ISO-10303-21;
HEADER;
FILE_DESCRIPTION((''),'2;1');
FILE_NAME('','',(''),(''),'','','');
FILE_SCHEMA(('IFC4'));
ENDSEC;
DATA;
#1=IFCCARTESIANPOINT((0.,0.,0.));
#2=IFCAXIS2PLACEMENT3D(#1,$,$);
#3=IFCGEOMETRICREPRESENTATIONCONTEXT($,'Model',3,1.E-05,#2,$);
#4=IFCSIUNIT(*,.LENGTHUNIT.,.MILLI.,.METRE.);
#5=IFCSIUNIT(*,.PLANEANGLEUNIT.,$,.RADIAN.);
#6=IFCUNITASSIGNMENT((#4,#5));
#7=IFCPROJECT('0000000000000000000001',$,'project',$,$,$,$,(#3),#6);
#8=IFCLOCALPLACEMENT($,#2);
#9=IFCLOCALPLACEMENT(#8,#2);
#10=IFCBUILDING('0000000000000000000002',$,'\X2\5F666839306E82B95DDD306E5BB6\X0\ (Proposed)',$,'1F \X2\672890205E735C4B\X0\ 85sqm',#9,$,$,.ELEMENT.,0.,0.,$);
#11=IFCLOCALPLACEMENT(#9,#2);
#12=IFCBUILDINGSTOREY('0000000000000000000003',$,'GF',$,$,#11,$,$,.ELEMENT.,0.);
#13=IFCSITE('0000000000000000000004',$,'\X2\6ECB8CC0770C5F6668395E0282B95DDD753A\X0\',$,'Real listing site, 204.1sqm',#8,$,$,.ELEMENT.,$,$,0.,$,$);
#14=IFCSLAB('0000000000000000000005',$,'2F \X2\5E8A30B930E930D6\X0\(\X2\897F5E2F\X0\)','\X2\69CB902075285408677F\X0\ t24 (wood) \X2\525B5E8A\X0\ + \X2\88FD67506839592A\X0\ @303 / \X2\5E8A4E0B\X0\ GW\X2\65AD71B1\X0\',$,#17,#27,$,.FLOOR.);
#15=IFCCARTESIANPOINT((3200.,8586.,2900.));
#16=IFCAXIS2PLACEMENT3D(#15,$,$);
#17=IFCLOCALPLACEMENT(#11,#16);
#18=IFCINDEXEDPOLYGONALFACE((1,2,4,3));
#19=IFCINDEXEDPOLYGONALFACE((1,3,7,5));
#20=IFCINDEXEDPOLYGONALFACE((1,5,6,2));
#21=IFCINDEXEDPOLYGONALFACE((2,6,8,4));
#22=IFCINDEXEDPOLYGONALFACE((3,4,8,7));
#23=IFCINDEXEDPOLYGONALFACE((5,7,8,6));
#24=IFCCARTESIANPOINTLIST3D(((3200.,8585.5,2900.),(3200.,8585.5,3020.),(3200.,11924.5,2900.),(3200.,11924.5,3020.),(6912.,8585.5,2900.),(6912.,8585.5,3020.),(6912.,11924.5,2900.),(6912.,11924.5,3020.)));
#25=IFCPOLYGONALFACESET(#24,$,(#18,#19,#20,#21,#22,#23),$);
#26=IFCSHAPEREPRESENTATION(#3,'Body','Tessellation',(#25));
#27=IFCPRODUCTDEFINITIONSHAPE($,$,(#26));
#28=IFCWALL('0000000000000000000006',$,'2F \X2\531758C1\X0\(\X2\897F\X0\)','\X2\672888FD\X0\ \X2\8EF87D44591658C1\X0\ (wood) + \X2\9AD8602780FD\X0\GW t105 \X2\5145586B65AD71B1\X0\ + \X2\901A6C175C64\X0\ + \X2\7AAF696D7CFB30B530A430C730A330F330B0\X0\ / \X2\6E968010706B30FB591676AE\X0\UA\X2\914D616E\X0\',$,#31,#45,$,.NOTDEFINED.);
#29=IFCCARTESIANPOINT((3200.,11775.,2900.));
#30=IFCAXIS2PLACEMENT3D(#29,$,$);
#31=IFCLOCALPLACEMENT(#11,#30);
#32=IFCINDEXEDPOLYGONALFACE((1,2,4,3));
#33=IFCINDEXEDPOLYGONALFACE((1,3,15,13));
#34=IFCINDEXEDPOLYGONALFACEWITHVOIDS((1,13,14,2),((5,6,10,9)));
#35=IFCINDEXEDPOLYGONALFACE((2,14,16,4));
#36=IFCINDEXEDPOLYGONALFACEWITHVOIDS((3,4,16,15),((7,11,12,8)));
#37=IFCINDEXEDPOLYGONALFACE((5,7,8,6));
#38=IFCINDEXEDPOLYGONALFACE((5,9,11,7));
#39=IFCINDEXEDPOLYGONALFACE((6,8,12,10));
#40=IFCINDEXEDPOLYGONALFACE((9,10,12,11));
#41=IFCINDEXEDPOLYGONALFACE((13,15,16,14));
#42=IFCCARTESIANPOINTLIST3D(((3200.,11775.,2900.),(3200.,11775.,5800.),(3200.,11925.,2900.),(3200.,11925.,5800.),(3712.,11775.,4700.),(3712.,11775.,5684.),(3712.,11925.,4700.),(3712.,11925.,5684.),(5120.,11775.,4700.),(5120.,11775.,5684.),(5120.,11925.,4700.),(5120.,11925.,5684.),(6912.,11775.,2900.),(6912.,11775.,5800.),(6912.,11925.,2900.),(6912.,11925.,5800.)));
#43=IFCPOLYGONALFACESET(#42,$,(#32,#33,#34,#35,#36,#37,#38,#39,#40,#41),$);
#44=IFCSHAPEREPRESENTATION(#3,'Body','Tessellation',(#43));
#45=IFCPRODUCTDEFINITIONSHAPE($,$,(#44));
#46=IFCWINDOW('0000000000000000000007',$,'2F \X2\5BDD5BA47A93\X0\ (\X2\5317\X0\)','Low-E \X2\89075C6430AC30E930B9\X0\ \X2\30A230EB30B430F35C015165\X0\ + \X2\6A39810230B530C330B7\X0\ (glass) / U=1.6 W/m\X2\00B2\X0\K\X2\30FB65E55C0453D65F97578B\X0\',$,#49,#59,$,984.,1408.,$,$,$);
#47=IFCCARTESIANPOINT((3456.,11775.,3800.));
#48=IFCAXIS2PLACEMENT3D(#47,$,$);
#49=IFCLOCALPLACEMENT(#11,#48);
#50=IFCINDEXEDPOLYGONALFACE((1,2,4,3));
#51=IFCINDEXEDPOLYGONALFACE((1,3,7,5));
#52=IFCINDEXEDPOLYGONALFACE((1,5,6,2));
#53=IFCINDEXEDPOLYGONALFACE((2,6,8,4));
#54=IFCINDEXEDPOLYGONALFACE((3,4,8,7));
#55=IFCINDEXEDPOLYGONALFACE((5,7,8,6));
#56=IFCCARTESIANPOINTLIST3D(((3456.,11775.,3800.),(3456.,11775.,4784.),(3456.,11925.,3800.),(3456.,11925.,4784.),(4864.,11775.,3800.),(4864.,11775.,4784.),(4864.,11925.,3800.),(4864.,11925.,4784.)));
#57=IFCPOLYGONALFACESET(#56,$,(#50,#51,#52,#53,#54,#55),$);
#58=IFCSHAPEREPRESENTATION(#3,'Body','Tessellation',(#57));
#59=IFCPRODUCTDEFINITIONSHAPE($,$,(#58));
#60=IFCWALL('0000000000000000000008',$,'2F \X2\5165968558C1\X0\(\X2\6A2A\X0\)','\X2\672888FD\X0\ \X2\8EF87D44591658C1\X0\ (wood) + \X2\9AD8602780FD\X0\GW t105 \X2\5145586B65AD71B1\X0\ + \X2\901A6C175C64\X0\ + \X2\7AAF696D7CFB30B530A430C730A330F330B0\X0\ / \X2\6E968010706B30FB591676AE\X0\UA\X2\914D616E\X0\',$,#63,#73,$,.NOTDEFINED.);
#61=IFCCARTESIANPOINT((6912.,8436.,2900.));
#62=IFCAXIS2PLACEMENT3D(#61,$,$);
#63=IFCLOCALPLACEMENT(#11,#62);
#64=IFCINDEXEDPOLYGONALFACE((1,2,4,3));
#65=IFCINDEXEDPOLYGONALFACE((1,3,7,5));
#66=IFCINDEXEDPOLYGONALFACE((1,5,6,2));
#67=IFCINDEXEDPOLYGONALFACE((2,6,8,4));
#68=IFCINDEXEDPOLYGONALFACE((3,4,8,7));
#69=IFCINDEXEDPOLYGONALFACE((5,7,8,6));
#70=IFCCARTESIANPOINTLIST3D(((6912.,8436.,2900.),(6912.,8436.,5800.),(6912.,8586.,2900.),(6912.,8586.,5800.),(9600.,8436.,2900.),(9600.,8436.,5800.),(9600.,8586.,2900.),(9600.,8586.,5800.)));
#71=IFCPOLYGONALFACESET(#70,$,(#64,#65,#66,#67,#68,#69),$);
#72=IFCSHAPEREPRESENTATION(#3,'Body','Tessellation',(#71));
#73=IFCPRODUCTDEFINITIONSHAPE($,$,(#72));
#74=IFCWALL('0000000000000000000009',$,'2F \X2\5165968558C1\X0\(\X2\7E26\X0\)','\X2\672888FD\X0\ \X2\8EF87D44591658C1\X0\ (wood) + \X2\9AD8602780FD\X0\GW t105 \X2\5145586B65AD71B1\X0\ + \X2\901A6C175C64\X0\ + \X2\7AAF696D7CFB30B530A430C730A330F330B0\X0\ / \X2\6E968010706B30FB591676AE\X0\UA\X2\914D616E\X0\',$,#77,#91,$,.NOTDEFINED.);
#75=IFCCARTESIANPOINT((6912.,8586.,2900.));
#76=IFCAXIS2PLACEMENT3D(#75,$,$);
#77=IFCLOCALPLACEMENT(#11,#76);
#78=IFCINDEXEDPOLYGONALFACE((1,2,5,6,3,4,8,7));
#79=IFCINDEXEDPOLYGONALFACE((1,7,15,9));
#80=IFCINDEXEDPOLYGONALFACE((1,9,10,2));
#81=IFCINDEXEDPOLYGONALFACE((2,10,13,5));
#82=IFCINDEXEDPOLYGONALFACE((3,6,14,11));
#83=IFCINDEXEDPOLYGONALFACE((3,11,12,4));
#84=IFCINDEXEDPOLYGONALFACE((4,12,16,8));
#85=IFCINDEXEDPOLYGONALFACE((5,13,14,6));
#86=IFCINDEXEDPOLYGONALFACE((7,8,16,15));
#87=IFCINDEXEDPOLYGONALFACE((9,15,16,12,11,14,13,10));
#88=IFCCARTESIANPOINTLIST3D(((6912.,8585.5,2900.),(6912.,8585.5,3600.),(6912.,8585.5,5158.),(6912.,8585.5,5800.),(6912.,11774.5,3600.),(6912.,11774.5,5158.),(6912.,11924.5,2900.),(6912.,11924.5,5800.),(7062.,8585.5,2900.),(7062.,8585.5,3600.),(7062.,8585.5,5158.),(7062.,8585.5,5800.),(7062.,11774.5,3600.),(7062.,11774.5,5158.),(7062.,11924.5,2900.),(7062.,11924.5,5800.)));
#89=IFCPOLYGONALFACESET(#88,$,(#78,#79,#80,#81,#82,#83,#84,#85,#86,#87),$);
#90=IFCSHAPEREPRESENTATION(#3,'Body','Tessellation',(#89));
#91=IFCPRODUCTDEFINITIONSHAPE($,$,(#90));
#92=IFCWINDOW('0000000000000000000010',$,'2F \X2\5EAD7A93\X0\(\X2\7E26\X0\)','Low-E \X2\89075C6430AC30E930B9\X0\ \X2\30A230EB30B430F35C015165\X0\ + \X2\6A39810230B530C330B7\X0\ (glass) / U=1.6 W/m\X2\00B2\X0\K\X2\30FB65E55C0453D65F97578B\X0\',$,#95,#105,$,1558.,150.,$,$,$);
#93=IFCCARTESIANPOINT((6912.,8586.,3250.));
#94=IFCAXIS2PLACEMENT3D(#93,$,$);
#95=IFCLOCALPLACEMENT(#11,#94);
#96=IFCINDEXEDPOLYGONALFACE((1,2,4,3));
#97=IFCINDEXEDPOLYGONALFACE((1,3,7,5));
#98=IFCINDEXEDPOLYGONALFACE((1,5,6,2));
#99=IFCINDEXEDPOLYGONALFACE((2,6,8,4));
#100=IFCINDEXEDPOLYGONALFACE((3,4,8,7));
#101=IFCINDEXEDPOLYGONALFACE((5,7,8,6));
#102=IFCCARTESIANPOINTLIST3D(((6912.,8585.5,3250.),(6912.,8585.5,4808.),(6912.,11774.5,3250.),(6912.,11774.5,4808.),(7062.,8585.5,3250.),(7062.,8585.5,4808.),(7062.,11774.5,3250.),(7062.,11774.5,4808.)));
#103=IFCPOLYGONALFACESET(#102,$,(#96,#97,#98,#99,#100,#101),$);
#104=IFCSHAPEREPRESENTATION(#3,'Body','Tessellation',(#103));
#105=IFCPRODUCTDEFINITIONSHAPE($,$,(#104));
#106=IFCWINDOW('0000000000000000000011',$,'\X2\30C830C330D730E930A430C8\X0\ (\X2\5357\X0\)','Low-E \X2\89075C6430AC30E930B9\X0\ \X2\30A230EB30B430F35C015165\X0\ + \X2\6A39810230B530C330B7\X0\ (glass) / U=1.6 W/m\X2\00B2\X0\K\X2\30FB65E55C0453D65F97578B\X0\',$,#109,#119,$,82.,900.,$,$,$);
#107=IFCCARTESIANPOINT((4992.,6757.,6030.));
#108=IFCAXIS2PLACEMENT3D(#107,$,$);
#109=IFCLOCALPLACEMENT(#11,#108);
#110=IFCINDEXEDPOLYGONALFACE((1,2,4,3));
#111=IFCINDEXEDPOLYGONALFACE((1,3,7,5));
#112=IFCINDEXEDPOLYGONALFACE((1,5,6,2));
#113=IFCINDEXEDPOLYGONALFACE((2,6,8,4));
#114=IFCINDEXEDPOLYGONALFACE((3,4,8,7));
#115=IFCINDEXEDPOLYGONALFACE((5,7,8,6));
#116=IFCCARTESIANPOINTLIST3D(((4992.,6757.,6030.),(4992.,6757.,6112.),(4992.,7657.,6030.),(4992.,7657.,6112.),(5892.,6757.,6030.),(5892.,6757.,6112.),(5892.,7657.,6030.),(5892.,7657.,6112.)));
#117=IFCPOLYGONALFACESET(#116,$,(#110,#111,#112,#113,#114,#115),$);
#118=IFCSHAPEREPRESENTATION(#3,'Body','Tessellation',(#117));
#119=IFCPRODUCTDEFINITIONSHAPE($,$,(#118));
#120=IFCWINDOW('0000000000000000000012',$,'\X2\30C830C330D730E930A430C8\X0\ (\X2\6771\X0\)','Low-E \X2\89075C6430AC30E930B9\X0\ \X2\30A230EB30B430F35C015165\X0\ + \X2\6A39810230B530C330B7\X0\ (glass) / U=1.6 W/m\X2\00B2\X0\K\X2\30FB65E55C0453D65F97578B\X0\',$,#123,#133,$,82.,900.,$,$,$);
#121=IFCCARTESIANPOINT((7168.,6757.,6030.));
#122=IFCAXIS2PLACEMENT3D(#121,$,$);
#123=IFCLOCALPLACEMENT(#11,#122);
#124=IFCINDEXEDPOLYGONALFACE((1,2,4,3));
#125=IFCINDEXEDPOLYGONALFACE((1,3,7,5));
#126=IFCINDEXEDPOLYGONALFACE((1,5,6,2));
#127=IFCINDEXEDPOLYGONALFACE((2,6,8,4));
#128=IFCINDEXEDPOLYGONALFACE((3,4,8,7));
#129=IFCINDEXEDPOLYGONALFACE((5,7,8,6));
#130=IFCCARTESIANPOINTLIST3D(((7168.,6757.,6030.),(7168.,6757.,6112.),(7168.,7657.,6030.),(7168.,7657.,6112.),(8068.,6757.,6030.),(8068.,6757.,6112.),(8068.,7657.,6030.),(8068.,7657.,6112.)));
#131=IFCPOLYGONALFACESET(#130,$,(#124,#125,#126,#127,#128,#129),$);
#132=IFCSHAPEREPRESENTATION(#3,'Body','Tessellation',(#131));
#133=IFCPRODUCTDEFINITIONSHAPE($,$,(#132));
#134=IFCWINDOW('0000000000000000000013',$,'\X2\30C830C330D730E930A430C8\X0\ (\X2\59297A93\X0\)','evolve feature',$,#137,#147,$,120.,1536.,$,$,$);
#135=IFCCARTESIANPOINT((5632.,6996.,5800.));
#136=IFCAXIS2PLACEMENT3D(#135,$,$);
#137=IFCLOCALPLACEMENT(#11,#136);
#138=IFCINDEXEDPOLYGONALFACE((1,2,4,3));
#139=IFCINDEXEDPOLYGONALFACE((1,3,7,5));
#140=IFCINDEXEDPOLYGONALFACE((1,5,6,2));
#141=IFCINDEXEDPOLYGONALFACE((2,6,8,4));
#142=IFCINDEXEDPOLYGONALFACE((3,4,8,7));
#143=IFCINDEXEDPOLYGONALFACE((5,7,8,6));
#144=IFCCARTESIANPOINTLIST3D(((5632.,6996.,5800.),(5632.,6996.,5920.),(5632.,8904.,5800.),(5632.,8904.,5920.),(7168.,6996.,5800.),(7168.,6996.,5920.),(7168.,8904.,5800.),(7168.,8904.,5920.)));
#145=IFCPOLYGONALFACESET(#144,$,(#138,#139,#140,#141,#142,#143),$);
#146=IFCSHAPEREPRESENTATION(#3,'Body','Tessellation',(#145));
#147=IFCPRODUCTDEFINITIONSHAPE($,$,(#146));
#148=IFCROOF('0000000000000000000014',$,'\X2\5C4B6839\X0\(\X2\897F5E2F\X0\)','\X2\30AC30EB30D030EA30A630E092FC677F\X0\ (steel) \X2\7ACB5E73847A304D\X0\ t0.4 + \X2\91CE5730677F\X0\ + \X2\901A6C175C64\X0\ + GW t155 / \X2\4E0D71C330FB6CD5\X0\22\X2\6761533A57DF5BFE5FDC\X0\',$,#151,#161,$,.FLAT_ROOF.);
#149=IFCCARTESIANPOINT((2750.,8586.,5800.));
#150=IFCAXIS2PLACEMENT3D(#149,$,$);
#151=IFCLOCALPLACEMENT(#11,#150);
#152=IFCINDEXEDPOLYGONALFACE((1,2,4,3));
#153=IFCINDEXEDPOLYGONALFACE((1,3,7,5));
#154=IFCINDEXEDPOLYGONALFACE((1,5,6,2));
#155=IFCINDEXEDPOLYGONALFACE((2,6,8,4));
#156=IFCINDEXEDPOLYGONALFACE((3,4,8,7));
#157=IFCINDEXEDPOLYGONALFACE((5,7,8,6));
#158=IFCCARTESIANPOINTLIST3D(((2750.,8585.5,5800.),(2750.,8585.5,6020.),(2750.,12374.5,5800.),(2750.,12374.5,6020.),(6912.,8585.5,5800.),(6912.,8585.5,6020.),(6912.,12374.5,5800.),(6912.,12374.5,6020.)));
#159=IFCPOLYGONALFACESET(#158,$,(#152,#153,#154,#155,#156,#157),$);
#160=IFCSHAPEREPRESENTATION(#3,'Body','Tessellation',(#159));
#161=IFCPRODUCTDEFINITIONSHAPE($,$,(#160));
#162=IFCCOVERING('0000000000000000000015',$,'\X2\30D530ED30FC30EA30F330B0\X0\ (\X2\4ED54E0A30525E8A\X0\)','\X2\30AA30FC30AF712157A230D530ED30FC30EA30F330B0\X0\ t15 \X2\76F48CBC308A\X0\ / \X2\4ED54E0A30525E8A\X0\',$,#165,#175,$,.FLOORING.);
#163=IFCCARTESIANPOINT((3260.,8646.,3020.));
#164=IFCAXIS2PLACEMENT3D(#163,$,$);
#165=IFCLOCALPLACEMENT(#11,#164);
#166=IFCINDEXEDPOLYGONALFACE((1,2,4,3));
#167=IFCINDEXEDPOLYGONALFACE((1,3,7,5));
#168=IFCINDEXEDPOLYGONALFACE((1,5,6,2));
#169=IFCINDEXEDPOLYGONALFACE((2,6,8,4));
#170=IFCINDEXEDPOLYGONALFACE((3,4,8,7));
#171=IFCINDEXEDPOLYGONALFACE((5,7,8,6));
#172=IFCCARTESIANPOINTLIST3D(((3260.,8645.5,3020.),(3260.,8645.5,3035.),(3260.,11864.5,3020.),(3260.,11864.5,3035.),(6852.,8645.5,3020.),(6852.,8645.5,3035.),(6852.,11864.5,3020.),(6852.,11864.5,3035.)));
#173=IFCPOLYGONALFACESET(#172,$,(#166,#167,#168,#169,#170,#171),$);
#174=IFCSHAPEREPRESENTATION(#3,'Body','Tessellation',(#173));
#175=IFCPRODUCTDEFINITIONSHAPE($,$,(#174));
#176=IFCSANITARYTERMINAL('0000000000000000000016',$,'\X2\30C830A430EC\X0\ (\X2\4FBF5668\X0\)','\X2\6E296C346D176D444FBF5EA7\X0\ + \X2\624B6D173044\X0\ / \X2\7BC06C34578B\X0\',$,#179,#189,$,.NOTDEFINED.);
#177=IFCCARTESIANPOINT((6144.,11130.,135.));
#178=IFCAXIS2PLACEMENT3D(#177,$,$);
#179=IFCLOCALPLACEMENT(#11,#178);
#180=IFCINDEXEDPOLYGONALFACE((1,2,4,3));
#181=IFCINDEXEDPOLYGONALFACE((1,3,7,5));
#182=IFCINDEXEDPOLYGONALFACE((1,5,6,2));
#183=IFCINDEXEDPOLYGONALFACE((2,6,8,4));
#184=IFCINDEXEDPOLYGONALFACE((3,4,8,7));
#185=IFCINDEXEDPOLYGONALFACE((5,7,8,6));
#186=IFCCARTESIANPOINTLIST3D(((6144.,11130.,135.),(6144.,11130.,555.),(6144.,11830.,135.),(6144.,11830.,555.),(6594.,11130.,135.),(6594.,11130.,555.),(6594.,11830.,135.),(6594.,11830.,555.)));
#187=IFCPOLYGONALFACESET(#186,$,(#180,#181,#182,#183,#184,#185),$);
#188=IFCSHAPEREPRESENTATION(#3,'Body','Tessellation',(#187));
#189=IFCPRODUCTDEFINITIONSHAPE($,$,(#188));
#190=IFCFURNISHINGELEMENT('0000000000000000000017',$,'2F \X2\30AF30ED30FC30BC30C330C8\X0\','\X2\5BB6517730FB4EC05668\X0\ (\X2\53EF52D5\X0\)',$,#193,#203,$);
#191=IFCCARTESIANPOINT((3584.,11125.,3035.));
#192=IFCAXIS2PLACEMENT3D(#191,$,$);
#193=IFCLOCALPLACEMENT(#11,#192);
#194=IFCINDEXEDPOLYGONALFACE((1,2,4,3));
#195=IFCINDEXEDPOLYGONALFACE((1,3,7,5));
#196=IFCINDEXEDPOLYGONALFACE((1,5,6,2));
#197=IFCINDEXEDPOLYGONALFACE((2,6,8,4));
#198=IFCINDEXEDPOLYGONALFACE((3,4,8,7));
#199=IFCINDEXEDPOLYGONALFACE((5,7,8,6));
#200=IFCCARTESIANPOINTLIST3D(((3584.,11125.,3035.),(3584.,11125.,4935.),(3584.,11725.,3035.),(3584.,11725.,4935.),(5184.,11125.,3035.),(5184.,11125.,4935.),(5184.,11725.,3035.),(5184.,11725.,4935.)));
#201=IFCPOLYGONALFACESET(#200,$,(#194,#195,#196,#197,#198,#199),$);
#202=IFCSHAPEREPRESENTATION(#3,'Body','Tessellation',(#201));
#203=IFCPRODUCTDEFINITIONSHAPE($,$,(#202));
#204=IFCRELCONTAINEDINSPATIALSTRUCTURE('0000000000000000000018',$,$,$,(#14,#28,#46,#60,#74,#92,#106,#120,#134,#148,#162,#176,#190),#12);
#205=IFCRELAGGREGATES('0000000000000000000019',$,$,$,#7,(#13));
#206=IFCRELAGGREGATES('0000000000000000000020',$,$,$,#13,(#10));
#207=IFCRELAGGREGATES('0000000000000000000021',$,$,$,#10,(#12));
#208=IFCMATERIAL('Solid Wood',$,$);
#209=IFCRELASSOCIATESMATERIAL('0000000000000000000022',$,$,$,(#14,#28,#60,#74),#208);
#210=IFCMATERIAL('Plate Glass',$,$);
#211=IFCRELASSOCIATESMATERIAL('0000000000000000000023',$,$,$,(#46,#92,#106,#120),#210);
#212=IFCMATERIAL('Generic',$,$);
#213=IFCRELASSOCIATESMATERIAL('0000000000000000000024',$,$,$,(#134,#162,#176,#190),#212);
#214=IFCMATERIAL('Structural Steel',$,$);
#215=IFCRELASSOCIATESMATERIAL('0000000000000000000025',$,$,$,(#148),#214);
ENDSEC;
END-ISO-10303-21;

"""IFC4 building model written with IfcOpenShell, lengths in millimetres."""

from ifc_helpers import new_model, si_unit, frame, frame_2d, origin, place, context, project, spatial, rectangle, extrude, material, element, fill, save


model = new_model("IFC4")

# Units and contexts
model_context = context("Model", 3, precision=1e-05, world=origin())
ifc_project = project(units=[si_unit("LENGTHUNIT", "METRE", prefix="MILLI"), si_unit("PLANEANGLEUNIT", "RADIAN")], contexts=[model_context])

# Site, building, storey
site_placement = place(None, origin())
site = spatial("IfcSite", under=ifc_project, at=site_placement, Name="滋賀県彦根市芹川町", ObjectType="Real listing site, 204.1sqm", CompositionType="ELEMENT", RefElevation=0.0)
building_placement = place(site_placement, origin())
building = spatial("IfcBuilding", under=site, at=building_placement, Name="彦根の芹川の家 (Proposed)", ObjectType="1F 木造平屋 85sqm", CompositionType="ELEMENT", ElevationOfRefHeight=0.0, ElevationOfTerrain=0.0)
storey_placement = place(building_placement, origin())
storey = spatial("IfcBuildingStorey", under=building, at=storey_placement, Name="GF", CompositionType="ELEMENT", Elevation=0.0)

# Slab
ifc_material_1 = material(Name="Solid Wood")
slab_placement = place(storey_placement, frame((3200.0, 8586.0, 2900.0)))
element("IfcSlab", 1, at=slab_placement, inside=storey, material=ifc_material_1, Name="2F 床スラブ(西帯)", Description="構造用合板 t24 (wood) 剛床 + 製材根太 @303 / 床下 GW断熱", PredefinedType="FLOOR", context=model_context, shape_type="SweptSolid", body=[
    extrude(rectangle(XDim=3712.0, YDim=3339.0, at=frame_2d((1856.0, 1669.0))), frame((3200.0, 8586.0, 2900.0)), (0.0, 0.0, 1.0), 120.0),
])

# Wall, opening, window
wall_1_placement = place(storey_placement, frame((3200.0, 11775.0, 2900.0)))
wall_1 = element("IfcWall", 2, at=wall_1_placement, inside=storey, material=ifc_material_1, Name="2F 北壁(西)", Description="木製 軸組外壁 (wood) + 高性能GW t105 充填断熱 + 通気層 + 窯業系サイディング / 準耐火・外皮UA配慮", PredefinedType="NOTDEFINED", context=model_context, shape_type="SweptSolid", body=[
    extrude(rectangle(XDim=3712.0, YDim=150.0, at=frame_2d((1856.0, 75.0))), frame((3200.0, 11775.0, 2900.0)), (0.0, 0.0, 1.0), 2900.0),
])
opening_1_placement = place(storey_placement, frame((3456.0, 11775.0, 3800.0)))
opening_1 = element("IfcOpeningElement", 3, at=opening_1_placement, cuts=wall_1, PredefinedType="NOTDEFINED", context=model_context, shape_type="SweptSolid", body=[
    extrude(rectangle(XDim=1408.0, YDim=150.0, at=frame_2d((704.0, 75.0))), frame((3456.0, 11775.0, 3800.0)), (0.0, 0.0, 1.0), 984.0),
])
ifc_material_2 = material(Name="Plate Glass")
window_1_placement = place(storey_placement, frame((3456.0, 11775.0, 3800.0)))
window_1 = element("IfcWindow", 4, at=window_1_placement, inside=storey, material=ifc_material_2, Name="2F 寝室窓 (北)", Description="Low-E 複層ガラス アルゴン封入 + 樹脂サッシ (glass) / U=1.6 W/m²K・日射取得型", OverallHeight=984.0, OverallWidth=1408.0, context=model_context, shape_type="SweptSolid", body=[
    extrude(rectangle(XDim=1408.0, YDim=150.0, at=frame_2d((704.0, 75.0))), frame((3456.0, 11775.0, 3800.0)), (0.0, 0.0, 1.0), 984.0),
])
fill(opening_1, window_1)

# Wall
wall_2_placement = place(storey_placement, frame((6912.0, 8436.0, 2900.0)))
element("IfcWall", 5, at=wall_2_placement, inside=storey, material=ifc_material_1, Name="2F 入隅壁(横)", Description="木製 軸組外壁 (wood) + 高性能GW t105 充填断熱 + 通気層 + 窯業系サイディング / 準耐火・外皮UA配慮", PredefinedType="NOTDEFINED", context=model_context, shape_type="SweptSolid", body=[
    extrude(rectangle(XDim=2688.0, YDim=150.0, at=frame_2d((1344.0, 75.0))), frame((6912.0, 8436.0, 2900.0)), (0.0, 0.0, 1.0), 2900.0),
])

# Wall, opening, window
wall_3_placement = place(storey_placement, frame((6912.0, 8586.0, 2900.0)))
wall_3 = element("IfcWall", 6, at=wall_3_placement, inside=storey, material=ifc_material_1, Name="2F 入隅壁(縦)", Description="木製 軸組外壁 (wood) + 高性能GW t105 充填断熱 + 通気層 + 窯業系サイディング / 準耐火・外皮UA配慮", PredefinedType="NOTDEFINED", context=model_context, shape_type="SweptSolid", body=[
    extrude(rectangle(XDim=150.0, YDim=3339.0, at=frame_2d((75.0, 1669.0))), frame((6912.0, 8586.0, 2900.0)), (0.0, 0.0, 1.0), 2900.0),
])
opening_2_placement = place(storey_placement, frame((6912.0, 8586.0, 3250.0)))
opening_2 = element("IfcOpeningElement", 7, at=opening_2_placement, cuts=wall_3, PredefinedType="NOTDEFINED", context=model_context, shape_type="SweptSolid", body=[
    extrude(rectangle(XDim=150.0, YDim=3189.0, at=frame_2d((75.0, 1594.0))), frame((6912.0, 8586.0, 3250.0)), (0.0, 0.0, 1.0), 1558.0),
])
window_2_placement = place(storey_placement, frame((6912.0, 8586.0, 3250.0)))
window_2 = element("IfcWindow", 8, at=window_2_placement, inside=storey, material=ifc_material_2, Name="2F 庭窓(縦)", Description="Low-E 複層ガラス アルゴン封入 + 樹脂サッシ (glass) / U=1.6 W/m²K・日射取得型", OverallHeight=1558.0, OverallWidth=150.0, context=model_context, shape_type="SweptSolid", body=[
    extrude(rectangle(XDim=150.0, YDim=3189.0, at=frame_2d((75.0, 1594.0))), frame((6912.0, 8586.0, 3250.0)), (0.0, 0.0, 1.0), 1558.0),
])
fill(opening_2, window_2)

# Windows
window_3_placement = place(storey_placement, frame((4992.0, 6757.0, 6030.0)))
element("IfcWindow", 9, at=window_3_placement, inside=storey, material=ifc_material_2, Name="トップライト (南)", Description="Low-E 複層ガラス アルゴン封入 + 樹脂サッシ (glass) / U=1.6 W/m²K・日射取得型", OverallHeight=82.0, OverallWidth=900.0, context=model_context, shape_type="SweptSolid", body=[
    extrude(rectangle(XDim=900.0, YDim=900.0, at=frame_2d((450.0, 450.0))), frame((4992.0, 6757.0, 6030.0)), (0.0, 0.0, 1.0), 82.0),
])
window_4_placement = place(storey_placement, frame((7168.0, 6757.0, 6030.0)))
element("IfcWindow", 10, at=window_4_placement, inside=storey, material=ifc_material_2, Name="トップライト (東)", Description="Low-E 複層ガラス アルゴン封入 + 樹脂サッシ (glass) / U=1.6 W/m²K・日射取得型", OverallHeight=82.0, OverallWidth=900.0, context=model_context, shape_type="SweptSolid", body=[
    extrude(rectangle(XDim=900.0, YDim=900.0, at=frame_2d((450.0, 450.0))), frame((7168.0, 6757.0, 6030.0)), (0.0, 0.0, 1.0), 82.0),
])
ifc_material_3 = material(Name="Generic")
window_5_placement = place(storey_placement, frame((5632.0, 6996.0, 5800.0)))
element("IfcWindow", 11, at=window_5_placement, inside=storey, material=ifc_material_3, Name="トップライト (天窓)", Description="evolve feature", OverallHeight=120.0, OverallWidth=1536.0, context=model_context, shape_type="SweptSolid", body=[
    extrude(rectangle(XDim=1536.0, YDim=1908.0, at=frame_2d((768.0, 954.0))), frame((5632.0, 6996.0, 5800.0)), (0.0, 0.0, 1.0), 120.0),
])

# Roof
ifc_material_4 = material(Name="Structural Steel")
for number, where, name in (
    (12, (2750.0, 8586.0, 5800.0), "屋根(西帯)"),
):
    element("IfcRoof", number, at=place(storey_placement, frame(where)), inside=storey, material=ifc_material_4, Name=name, Description="ガルバリウム鋼板 (steel) 立平葺き t0.4 + 野地板 + 通気層 + GW t155 / 不燃・法22条区域対応", PredefinedType="FLAT_ROOF", context=model_context, shape_type="SweptSolid", body=[
        extrude(rectangle(XDim=4162.0, YDim=3789.0, at=frame_2d((2081.0, 1894.0))), frame((2750.0, 8586.0, 5800.0)), (0.0, 0.0, 1.0), 220.0),
    ])

# Covering
covering_placement = place(storey_placement, frame((3260.0, 8646.0, 3020.0)))
element("IfcCovering", 13, at=covering_placement, inside=storey, material=ifc_material_3, Name="フローリング (仕上げ床)", Description="オーク無垢フローリング t15 直貼り / 仕上げ床", PredefinedType="FLOORING", context=model_context, shape_type="SweptSolid", body=[
    extrude(rectangle(XDim=3592.0, YDim=3219.0, at=frame_2d((1796.0, 1609.0))), frame((3260.0, 8646.0, 3020.0)), (0.0, 0.0, 1.0), 15.0),
])

# Sanitary terminal
sanitary_terminal_placement = place(storey_placement, frame((6144.0, 11130.0, 135.0)))
element("IfcSanitaryTerminal", 14, at=sanitary_terminal_placement, inside=storey, material=ifc_material_3, Name="トイレ (便器)", Description="温水洗浄便座 + 手洗い / 節水型", PredefinedType="NOTDEFINED", context=model_context, shape_type="SweptSolid", body=[
    extrude(rectangle(XDim=450.0, YDim=700.0, at=frame_2d((225.0, 350.0))), frame((6144.0, 11130.0, 135.0)), (0.0, 0.0, 1.0), 420.0),
])

# Furnishing element
furnishing_1_placement = place(storey_placement, frame((3584.0, 11125.0, 3035.0)))
element("IfcFurnishingElement", 15, at=furnishing_1_placement, inside=storey, material=ifc_material_3, Name="2F クローゼット", Description="家具・什器 (可動)", context=model_context, shape_type="SweptSolid", body=[
    extrude(rectangle(XDim=1600.0, YDim=600.0, at=frame_2d((800.0, 300.0))), frame((3584.0, 11125.0, 3035.0)), (0.0, 0.0, 1.0), 1900.0),
])

save(model, "model.ifc")
